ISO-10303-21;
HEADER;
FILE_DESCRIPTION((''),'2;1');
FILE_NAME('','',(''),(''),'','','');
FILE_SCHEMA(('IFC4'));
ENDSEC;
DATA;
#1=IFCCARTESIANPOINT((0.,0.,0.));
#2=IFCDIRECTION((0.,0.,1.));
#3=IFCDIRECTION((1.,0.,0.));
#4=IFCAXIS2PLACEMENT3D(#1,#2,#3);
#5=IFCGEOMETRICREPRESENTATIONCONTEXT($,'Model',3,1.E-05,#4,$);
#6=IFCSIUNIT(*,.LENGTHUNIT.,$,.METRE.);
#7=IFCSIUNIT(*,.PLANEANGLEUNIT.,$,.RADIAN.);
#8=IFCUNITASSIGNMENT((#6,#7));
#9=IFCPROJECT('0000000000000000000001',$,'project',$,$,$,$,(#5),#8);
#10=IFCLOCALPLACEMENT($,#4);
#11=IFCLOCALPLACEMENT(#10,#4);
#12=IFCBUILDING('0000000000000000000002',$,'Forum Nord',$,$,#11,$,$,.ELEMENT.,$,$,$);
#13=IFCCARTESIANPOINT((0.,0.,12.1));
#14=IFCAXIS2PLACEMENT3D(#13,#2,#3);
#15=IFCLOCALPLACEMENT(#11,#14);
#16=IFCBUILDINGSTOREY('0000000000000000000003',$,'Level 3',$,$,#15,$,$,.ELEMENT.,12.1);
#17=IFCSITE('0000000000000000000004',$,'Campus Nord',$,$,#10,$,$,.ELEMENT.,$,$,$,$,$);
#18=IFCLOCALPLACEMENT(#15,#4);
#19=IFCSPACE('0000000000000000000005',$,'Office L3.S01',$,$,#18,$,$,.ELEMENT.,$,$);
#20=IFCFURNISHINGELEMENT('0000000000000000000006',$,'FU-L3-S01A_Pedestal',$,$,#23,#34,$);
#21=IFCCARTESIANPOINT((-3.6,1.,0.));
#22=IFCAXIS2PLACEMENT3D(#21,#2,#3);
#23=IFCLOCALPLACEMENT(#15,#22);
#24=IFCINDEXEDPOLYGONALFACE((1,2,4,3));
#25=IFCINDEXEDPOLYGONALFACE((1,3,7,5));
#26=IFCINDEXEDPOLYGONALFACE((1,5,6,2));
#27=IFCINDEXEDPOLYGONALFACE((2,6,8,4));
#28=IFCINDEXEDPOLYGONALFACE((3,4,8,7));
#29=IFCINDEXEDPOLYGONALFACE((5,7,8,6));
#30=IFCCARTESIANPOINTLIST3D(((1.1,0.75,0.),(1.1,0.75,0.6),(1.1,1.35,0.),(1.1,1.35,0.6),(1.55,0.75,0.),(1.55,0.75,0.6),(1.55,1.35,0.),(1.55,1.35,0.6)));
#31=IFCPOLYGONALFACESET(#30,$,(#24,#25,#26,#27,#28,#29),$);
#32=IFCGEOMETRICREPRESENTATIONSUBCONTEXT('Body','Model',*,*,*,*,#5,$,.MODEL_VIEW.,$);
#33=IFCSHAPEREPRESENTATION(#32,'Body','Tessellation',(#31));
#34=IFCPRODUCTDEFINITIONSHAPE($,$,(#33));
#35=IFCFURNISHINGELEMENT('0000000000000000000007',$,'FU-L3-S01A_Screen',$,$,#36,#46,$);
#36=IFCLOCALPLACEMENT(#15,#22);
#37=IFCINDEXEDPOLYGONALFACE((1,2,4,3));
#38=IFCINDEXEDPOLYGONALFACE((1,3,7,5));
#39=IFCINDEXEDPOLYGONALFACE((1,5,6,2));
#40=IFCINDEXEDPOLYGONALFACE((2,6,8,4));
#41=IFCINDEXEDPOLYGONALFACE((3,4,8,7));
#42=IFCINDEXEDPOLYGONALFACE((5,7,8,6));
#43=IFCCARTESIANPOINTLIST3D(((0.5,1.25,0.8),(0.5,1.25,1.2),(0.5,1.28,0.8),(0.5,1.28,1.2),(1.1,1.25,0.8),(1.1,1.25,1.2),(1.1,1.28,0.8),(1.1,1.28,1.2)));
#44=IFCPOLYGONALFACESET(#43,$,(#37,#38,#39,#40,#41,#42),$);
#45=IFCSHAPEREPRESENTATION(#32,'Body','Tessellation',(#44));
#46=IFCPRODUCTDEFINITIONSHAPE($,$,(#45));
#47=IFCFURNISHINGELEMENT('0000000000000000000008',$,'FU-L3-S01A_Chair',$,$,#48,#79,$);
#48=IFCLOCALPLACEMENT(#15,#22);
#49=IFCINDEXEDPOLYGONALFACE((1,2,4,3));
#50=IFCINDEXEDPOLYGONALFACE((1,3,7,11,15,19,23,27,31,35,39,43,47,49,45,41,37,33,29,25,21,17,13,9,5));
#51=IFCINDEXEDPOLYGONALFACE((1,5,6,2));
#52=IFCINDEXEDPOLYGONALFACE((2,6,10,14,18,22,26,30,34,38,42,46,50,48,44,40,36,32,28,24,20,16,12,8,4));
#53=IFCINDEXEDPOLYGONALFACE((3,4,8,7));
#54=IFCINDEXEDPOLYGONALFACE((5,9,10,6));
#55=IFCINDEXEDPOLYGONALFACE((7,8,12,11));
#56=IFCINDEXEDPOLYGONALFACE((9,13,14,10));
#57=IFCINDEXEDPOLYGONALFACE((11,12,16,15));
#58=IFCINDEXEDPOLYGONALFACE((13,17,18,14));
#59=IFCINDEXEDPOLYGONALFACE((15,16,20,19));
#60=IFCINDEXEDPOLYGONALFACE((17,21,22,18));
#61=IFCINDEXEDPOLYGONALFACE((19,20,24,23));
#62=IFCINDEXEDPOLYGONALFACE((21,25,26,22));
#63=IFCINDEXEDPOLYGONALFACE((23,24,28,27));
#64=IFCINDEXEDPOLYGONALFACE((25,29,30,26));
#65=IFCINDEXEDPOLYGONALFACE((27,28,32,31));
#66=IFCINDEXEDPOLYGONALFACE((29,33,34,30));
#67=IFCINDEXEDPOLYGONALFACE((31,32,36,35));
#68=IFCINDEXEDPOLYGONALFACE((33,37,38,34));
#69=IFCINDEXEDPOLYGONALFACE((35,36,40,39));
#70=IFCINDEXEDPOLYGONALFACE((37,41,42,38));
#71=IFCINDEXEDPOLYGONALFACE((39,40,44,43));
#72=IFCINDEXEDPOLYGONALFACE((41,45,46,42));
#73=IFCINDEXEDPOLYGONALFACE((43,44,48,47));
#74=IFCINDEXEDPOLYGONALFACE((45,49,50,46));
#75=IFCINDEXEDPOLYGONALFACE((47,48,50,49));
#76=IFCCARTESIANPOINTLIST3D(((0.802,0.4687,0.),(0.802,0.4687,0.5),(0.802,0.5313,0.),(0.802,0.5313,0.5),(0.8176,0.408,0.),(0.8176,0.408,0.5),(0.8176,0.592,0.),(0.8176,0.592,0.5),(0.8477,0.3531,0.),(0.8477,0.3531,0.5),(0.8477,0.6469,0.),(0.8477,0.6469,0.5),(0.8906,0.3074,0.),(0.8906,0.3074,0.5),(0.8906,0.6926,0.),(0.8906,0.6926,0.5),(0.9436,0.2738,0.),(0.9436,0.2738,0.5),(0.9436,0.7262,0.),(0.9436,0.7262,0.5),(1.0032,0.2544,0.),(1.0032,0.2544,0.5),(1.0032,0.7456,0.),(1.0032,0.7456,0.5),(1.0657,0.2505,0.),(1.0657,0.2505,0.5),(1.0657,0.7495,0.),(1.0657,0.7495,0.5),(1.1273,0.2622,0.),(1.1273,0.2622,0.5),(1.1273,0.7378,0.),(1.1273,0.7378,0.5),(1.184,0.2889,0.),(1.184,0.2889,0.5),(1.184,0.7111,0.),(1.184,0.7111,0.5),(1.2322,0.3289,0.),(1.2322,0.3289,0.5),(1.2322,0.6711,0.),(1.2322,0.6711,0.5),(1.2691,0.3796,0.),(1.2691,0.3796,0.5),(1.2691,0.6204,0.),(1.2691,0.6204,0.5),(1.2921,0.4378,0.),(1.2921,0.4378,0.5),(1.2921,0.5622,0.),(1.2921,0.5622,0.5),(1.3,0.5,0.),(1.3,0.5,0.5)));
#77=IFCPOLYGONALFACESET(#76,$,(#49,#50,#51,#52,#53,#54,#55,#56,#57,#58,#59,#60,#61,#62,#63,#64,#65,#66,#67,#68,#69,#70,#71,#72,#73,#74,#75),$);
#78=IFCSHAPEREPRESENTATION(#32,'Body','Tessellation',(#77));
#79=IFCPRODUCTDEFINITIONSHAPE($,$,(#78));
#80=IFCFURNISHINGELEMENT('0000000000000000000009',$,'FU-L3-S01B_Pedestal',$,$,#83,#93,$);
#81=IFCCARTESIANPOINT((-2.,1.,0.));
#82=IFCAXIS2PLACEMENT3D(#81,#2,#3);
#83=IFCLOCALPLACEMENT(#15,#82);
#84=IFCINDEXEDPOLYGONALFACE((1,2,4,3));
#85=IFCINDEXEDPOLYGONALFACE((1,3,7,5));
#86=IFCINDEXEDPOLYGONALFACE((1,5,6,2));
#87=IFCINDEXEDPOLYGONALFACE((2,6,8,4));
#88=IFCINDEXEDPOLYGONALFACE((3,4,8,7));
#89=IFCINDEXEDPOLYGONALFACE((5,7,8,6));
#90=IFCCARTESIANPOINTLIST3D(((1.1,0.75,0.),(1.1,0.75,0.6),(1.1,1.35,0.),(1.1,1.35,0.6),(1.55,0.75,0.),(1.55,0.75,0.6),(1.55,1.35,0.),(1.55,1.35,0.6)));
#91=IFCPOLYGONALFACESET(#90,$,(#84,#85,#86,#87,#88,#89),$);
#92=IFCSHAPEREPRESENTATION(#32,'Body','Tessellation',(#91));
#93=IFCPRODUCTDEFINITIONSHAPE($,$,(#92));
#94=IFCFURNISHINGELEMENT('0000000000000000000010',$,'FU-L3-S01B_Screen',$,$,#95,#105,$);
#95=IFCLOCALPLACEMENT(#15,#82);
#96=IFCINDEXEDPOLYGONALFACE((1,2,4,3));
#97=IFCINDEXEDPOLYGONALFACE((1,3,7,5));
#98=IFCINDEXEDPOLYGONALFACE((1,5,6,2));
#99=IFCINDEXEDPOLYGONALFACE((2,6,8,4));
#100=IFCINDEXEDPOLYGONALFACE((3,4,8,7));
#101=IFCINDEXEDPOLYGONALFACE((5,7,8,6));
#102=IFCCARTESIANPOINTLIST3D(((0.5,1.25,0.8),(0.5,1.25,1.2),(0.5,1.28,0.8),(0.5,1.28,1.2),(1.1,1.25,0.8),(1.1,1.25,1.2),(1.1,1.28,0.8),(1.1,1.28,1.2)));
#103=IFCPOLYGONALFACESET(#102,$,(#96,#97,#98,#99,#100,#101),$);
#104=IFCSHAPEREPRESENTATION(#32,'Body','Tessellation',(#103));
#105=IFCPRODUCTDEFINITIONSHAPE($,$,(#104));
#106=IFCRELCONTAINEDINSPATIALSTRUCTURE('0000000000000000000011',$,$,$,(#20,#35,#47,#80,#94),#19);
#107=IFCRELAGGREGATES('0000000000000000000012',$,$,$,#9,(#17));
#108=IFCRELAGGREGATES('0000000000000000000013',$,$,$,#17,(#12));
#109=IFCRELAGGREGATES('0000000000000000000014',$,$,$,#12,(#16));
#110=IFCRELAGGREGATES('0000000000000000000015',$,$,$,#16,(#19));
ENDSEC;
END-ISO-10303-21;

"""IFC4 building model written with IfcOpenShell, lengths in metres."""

from ifc_helpers import new_model, si_unit, frame, frame_2d, origin_with_axes, place, context, subcontext, project, spatial, rectangle, circle, extrude, element, save


model = new_model("IFC4")

# Units and contexts
model_context = context("Model", 3, precision=1e-05, world=origin_with_axes())
body_context = subcontext(model_context, "Body", "Model", "MODEL_VIEW")
ifc_project = project(units=[si_unit("LENGTHUNIT", "METRE"), si_unit("PLANEANGLEUNIT", "RADIAN")], contexts=[model_context])

# Site, building, storey
site_placement = place(None, origin_with_axes())
site = spatial("IfcSite", under=ifc_project, at=site_placement, Name="Campus Nord", CompositionType="ELEMENT")
building_placement = place(site_placement, origin_with_axes())
building = spatial("IfcBuilding", under=site, at=building_placement, Name="Forum Nord", CompositionType="ELEMENT")
storey_placement = place(building_placement, frame((0.0, 0.0, 12.1), z_axis=(0.0, 0.0, 1.0), x_axis=(1.0, 0.0, 0.0)))
storey = spatial("IfcBuildingStorey", under=building, at=storey_placement, Name="Level 3", CompositionType="ELEMENT", Elevation=12.1)

# Shared definitions
space_placement = place(storey_placement, origin_with_axes())
space = spatial("IfcSpace", under=storey, at=space_placement, Name="Office L3.S01", CompositionType="ELEMENT")

# Furnishing elements
furnishing_1_placement = place(storey_placement, frame((-3.6, 1.0, 0.0), z_axis=(0.0, 0.0, 1.0), x_axis=(1.0, 0.0, 0.0)))
element("IfcFurnishingElement", 1, at=furnishing_1_placement, inside=space, Name="FU-L3-S01A_Pedestal", context=body_context, shape_type="SweptSolid", body=[
    extrude(rectangle(XDim=0.45, YDim=0.6, at=frame_2d((1.325, 1.05), x_axis=(1.0, 0.0))), origin_with_axes(), (0.0, 0.0, 1.0), 0.6),
])
furnishing_2_placement = place(storey_placement, frame((-3.6, 1.0, 0.0), z_axis=(0.0, 0.0, 1.0), x_axis=(1.0, 0.0, 0.0)))
element("IfcFurnishingElement", 2, at=furnishing_2_placement, inside=space, Name="FU-L3-S01A_Screen", context=body_context, shape_type="SweptSolid", body=[
    extrude(rectangle(XDim=0.6, YDim=0.03, at=frame_2d((0.8, 1.265), x_axis=(1.0, 0.0))), frame((0.0, 0.0, 0.8), z_axis=(0.0, 0.0, 1.0), x_axis=(1.0, 0.0, 0.0)), (0.0, 0.0, 1.0), 0.4),
])
furnishing_3_placement = place(storey_placement, frame((-3.6, 1.0, 0.0), z_axis=(0.0, 0.0, 1.0), x_axis=(1.0, 0.0, 0.0)))
element("IfcFurnishingElement", 3, at=furnishing_3_placement, inside=space, Name="FU-L3-S01A_Chair", context=body_context, shape_type="SweptSolid", body=[
    extrude(circle(Radius=0.25, at=frame_2d((1.05, 0.5), x_axis=(1.0, 0.0))), origin_with_axes(), (0.0, 0.0, 1.0), 0.5),
])
furnishing_4_placement = place(storey_placement, frame((-2.0, 1.0, 0.0), z_axis=(0.0, 0.0, 1.0), x_axis=(1.0, 0.0, 0.0)))
element("IfcFurnishingElement", 4, at=furnishing_4_placement, inside=space, Name="FU-L3-S01B_Pedestal", context=body_context, shape_type="SweptSolid", body=[
    extrude(rectangle(XDim=0.45, YDim=0.6, at=frame_2d((1.325, 1.05), x_axis=(1.0, 0.0))), origin_with_axes(), (0.0, 0.0, 1.0), 0.6),
])
furnishing_5_placement = place(storey_placement, frame((-2.0, 1.0, 0.0), z_axis=(0.0, 0.0, 1.0), x_axis=(1.0, 0.0, 0.0)))
element("IfcFurnishingElement", 5, at=furnishing_5_placement, inside=space, Name="FU-L3-S01B_Screen", context=body_context, shape_type="SweptSolid", body=[
    extrude(rectangle(XDim=0.6, YDim=0.03, at=frame_2d((0.8, 1.265), x_axis=(1.0, 0.0))), frame((0.0, 0.0, 0.8), z_axis=(0.0, 0.0, 1.0), x_axis=(1.0, 0.0, 0.0)), (0.0, 0.0, 1.0), 0.4),
])

save(model, "model.ifc")
